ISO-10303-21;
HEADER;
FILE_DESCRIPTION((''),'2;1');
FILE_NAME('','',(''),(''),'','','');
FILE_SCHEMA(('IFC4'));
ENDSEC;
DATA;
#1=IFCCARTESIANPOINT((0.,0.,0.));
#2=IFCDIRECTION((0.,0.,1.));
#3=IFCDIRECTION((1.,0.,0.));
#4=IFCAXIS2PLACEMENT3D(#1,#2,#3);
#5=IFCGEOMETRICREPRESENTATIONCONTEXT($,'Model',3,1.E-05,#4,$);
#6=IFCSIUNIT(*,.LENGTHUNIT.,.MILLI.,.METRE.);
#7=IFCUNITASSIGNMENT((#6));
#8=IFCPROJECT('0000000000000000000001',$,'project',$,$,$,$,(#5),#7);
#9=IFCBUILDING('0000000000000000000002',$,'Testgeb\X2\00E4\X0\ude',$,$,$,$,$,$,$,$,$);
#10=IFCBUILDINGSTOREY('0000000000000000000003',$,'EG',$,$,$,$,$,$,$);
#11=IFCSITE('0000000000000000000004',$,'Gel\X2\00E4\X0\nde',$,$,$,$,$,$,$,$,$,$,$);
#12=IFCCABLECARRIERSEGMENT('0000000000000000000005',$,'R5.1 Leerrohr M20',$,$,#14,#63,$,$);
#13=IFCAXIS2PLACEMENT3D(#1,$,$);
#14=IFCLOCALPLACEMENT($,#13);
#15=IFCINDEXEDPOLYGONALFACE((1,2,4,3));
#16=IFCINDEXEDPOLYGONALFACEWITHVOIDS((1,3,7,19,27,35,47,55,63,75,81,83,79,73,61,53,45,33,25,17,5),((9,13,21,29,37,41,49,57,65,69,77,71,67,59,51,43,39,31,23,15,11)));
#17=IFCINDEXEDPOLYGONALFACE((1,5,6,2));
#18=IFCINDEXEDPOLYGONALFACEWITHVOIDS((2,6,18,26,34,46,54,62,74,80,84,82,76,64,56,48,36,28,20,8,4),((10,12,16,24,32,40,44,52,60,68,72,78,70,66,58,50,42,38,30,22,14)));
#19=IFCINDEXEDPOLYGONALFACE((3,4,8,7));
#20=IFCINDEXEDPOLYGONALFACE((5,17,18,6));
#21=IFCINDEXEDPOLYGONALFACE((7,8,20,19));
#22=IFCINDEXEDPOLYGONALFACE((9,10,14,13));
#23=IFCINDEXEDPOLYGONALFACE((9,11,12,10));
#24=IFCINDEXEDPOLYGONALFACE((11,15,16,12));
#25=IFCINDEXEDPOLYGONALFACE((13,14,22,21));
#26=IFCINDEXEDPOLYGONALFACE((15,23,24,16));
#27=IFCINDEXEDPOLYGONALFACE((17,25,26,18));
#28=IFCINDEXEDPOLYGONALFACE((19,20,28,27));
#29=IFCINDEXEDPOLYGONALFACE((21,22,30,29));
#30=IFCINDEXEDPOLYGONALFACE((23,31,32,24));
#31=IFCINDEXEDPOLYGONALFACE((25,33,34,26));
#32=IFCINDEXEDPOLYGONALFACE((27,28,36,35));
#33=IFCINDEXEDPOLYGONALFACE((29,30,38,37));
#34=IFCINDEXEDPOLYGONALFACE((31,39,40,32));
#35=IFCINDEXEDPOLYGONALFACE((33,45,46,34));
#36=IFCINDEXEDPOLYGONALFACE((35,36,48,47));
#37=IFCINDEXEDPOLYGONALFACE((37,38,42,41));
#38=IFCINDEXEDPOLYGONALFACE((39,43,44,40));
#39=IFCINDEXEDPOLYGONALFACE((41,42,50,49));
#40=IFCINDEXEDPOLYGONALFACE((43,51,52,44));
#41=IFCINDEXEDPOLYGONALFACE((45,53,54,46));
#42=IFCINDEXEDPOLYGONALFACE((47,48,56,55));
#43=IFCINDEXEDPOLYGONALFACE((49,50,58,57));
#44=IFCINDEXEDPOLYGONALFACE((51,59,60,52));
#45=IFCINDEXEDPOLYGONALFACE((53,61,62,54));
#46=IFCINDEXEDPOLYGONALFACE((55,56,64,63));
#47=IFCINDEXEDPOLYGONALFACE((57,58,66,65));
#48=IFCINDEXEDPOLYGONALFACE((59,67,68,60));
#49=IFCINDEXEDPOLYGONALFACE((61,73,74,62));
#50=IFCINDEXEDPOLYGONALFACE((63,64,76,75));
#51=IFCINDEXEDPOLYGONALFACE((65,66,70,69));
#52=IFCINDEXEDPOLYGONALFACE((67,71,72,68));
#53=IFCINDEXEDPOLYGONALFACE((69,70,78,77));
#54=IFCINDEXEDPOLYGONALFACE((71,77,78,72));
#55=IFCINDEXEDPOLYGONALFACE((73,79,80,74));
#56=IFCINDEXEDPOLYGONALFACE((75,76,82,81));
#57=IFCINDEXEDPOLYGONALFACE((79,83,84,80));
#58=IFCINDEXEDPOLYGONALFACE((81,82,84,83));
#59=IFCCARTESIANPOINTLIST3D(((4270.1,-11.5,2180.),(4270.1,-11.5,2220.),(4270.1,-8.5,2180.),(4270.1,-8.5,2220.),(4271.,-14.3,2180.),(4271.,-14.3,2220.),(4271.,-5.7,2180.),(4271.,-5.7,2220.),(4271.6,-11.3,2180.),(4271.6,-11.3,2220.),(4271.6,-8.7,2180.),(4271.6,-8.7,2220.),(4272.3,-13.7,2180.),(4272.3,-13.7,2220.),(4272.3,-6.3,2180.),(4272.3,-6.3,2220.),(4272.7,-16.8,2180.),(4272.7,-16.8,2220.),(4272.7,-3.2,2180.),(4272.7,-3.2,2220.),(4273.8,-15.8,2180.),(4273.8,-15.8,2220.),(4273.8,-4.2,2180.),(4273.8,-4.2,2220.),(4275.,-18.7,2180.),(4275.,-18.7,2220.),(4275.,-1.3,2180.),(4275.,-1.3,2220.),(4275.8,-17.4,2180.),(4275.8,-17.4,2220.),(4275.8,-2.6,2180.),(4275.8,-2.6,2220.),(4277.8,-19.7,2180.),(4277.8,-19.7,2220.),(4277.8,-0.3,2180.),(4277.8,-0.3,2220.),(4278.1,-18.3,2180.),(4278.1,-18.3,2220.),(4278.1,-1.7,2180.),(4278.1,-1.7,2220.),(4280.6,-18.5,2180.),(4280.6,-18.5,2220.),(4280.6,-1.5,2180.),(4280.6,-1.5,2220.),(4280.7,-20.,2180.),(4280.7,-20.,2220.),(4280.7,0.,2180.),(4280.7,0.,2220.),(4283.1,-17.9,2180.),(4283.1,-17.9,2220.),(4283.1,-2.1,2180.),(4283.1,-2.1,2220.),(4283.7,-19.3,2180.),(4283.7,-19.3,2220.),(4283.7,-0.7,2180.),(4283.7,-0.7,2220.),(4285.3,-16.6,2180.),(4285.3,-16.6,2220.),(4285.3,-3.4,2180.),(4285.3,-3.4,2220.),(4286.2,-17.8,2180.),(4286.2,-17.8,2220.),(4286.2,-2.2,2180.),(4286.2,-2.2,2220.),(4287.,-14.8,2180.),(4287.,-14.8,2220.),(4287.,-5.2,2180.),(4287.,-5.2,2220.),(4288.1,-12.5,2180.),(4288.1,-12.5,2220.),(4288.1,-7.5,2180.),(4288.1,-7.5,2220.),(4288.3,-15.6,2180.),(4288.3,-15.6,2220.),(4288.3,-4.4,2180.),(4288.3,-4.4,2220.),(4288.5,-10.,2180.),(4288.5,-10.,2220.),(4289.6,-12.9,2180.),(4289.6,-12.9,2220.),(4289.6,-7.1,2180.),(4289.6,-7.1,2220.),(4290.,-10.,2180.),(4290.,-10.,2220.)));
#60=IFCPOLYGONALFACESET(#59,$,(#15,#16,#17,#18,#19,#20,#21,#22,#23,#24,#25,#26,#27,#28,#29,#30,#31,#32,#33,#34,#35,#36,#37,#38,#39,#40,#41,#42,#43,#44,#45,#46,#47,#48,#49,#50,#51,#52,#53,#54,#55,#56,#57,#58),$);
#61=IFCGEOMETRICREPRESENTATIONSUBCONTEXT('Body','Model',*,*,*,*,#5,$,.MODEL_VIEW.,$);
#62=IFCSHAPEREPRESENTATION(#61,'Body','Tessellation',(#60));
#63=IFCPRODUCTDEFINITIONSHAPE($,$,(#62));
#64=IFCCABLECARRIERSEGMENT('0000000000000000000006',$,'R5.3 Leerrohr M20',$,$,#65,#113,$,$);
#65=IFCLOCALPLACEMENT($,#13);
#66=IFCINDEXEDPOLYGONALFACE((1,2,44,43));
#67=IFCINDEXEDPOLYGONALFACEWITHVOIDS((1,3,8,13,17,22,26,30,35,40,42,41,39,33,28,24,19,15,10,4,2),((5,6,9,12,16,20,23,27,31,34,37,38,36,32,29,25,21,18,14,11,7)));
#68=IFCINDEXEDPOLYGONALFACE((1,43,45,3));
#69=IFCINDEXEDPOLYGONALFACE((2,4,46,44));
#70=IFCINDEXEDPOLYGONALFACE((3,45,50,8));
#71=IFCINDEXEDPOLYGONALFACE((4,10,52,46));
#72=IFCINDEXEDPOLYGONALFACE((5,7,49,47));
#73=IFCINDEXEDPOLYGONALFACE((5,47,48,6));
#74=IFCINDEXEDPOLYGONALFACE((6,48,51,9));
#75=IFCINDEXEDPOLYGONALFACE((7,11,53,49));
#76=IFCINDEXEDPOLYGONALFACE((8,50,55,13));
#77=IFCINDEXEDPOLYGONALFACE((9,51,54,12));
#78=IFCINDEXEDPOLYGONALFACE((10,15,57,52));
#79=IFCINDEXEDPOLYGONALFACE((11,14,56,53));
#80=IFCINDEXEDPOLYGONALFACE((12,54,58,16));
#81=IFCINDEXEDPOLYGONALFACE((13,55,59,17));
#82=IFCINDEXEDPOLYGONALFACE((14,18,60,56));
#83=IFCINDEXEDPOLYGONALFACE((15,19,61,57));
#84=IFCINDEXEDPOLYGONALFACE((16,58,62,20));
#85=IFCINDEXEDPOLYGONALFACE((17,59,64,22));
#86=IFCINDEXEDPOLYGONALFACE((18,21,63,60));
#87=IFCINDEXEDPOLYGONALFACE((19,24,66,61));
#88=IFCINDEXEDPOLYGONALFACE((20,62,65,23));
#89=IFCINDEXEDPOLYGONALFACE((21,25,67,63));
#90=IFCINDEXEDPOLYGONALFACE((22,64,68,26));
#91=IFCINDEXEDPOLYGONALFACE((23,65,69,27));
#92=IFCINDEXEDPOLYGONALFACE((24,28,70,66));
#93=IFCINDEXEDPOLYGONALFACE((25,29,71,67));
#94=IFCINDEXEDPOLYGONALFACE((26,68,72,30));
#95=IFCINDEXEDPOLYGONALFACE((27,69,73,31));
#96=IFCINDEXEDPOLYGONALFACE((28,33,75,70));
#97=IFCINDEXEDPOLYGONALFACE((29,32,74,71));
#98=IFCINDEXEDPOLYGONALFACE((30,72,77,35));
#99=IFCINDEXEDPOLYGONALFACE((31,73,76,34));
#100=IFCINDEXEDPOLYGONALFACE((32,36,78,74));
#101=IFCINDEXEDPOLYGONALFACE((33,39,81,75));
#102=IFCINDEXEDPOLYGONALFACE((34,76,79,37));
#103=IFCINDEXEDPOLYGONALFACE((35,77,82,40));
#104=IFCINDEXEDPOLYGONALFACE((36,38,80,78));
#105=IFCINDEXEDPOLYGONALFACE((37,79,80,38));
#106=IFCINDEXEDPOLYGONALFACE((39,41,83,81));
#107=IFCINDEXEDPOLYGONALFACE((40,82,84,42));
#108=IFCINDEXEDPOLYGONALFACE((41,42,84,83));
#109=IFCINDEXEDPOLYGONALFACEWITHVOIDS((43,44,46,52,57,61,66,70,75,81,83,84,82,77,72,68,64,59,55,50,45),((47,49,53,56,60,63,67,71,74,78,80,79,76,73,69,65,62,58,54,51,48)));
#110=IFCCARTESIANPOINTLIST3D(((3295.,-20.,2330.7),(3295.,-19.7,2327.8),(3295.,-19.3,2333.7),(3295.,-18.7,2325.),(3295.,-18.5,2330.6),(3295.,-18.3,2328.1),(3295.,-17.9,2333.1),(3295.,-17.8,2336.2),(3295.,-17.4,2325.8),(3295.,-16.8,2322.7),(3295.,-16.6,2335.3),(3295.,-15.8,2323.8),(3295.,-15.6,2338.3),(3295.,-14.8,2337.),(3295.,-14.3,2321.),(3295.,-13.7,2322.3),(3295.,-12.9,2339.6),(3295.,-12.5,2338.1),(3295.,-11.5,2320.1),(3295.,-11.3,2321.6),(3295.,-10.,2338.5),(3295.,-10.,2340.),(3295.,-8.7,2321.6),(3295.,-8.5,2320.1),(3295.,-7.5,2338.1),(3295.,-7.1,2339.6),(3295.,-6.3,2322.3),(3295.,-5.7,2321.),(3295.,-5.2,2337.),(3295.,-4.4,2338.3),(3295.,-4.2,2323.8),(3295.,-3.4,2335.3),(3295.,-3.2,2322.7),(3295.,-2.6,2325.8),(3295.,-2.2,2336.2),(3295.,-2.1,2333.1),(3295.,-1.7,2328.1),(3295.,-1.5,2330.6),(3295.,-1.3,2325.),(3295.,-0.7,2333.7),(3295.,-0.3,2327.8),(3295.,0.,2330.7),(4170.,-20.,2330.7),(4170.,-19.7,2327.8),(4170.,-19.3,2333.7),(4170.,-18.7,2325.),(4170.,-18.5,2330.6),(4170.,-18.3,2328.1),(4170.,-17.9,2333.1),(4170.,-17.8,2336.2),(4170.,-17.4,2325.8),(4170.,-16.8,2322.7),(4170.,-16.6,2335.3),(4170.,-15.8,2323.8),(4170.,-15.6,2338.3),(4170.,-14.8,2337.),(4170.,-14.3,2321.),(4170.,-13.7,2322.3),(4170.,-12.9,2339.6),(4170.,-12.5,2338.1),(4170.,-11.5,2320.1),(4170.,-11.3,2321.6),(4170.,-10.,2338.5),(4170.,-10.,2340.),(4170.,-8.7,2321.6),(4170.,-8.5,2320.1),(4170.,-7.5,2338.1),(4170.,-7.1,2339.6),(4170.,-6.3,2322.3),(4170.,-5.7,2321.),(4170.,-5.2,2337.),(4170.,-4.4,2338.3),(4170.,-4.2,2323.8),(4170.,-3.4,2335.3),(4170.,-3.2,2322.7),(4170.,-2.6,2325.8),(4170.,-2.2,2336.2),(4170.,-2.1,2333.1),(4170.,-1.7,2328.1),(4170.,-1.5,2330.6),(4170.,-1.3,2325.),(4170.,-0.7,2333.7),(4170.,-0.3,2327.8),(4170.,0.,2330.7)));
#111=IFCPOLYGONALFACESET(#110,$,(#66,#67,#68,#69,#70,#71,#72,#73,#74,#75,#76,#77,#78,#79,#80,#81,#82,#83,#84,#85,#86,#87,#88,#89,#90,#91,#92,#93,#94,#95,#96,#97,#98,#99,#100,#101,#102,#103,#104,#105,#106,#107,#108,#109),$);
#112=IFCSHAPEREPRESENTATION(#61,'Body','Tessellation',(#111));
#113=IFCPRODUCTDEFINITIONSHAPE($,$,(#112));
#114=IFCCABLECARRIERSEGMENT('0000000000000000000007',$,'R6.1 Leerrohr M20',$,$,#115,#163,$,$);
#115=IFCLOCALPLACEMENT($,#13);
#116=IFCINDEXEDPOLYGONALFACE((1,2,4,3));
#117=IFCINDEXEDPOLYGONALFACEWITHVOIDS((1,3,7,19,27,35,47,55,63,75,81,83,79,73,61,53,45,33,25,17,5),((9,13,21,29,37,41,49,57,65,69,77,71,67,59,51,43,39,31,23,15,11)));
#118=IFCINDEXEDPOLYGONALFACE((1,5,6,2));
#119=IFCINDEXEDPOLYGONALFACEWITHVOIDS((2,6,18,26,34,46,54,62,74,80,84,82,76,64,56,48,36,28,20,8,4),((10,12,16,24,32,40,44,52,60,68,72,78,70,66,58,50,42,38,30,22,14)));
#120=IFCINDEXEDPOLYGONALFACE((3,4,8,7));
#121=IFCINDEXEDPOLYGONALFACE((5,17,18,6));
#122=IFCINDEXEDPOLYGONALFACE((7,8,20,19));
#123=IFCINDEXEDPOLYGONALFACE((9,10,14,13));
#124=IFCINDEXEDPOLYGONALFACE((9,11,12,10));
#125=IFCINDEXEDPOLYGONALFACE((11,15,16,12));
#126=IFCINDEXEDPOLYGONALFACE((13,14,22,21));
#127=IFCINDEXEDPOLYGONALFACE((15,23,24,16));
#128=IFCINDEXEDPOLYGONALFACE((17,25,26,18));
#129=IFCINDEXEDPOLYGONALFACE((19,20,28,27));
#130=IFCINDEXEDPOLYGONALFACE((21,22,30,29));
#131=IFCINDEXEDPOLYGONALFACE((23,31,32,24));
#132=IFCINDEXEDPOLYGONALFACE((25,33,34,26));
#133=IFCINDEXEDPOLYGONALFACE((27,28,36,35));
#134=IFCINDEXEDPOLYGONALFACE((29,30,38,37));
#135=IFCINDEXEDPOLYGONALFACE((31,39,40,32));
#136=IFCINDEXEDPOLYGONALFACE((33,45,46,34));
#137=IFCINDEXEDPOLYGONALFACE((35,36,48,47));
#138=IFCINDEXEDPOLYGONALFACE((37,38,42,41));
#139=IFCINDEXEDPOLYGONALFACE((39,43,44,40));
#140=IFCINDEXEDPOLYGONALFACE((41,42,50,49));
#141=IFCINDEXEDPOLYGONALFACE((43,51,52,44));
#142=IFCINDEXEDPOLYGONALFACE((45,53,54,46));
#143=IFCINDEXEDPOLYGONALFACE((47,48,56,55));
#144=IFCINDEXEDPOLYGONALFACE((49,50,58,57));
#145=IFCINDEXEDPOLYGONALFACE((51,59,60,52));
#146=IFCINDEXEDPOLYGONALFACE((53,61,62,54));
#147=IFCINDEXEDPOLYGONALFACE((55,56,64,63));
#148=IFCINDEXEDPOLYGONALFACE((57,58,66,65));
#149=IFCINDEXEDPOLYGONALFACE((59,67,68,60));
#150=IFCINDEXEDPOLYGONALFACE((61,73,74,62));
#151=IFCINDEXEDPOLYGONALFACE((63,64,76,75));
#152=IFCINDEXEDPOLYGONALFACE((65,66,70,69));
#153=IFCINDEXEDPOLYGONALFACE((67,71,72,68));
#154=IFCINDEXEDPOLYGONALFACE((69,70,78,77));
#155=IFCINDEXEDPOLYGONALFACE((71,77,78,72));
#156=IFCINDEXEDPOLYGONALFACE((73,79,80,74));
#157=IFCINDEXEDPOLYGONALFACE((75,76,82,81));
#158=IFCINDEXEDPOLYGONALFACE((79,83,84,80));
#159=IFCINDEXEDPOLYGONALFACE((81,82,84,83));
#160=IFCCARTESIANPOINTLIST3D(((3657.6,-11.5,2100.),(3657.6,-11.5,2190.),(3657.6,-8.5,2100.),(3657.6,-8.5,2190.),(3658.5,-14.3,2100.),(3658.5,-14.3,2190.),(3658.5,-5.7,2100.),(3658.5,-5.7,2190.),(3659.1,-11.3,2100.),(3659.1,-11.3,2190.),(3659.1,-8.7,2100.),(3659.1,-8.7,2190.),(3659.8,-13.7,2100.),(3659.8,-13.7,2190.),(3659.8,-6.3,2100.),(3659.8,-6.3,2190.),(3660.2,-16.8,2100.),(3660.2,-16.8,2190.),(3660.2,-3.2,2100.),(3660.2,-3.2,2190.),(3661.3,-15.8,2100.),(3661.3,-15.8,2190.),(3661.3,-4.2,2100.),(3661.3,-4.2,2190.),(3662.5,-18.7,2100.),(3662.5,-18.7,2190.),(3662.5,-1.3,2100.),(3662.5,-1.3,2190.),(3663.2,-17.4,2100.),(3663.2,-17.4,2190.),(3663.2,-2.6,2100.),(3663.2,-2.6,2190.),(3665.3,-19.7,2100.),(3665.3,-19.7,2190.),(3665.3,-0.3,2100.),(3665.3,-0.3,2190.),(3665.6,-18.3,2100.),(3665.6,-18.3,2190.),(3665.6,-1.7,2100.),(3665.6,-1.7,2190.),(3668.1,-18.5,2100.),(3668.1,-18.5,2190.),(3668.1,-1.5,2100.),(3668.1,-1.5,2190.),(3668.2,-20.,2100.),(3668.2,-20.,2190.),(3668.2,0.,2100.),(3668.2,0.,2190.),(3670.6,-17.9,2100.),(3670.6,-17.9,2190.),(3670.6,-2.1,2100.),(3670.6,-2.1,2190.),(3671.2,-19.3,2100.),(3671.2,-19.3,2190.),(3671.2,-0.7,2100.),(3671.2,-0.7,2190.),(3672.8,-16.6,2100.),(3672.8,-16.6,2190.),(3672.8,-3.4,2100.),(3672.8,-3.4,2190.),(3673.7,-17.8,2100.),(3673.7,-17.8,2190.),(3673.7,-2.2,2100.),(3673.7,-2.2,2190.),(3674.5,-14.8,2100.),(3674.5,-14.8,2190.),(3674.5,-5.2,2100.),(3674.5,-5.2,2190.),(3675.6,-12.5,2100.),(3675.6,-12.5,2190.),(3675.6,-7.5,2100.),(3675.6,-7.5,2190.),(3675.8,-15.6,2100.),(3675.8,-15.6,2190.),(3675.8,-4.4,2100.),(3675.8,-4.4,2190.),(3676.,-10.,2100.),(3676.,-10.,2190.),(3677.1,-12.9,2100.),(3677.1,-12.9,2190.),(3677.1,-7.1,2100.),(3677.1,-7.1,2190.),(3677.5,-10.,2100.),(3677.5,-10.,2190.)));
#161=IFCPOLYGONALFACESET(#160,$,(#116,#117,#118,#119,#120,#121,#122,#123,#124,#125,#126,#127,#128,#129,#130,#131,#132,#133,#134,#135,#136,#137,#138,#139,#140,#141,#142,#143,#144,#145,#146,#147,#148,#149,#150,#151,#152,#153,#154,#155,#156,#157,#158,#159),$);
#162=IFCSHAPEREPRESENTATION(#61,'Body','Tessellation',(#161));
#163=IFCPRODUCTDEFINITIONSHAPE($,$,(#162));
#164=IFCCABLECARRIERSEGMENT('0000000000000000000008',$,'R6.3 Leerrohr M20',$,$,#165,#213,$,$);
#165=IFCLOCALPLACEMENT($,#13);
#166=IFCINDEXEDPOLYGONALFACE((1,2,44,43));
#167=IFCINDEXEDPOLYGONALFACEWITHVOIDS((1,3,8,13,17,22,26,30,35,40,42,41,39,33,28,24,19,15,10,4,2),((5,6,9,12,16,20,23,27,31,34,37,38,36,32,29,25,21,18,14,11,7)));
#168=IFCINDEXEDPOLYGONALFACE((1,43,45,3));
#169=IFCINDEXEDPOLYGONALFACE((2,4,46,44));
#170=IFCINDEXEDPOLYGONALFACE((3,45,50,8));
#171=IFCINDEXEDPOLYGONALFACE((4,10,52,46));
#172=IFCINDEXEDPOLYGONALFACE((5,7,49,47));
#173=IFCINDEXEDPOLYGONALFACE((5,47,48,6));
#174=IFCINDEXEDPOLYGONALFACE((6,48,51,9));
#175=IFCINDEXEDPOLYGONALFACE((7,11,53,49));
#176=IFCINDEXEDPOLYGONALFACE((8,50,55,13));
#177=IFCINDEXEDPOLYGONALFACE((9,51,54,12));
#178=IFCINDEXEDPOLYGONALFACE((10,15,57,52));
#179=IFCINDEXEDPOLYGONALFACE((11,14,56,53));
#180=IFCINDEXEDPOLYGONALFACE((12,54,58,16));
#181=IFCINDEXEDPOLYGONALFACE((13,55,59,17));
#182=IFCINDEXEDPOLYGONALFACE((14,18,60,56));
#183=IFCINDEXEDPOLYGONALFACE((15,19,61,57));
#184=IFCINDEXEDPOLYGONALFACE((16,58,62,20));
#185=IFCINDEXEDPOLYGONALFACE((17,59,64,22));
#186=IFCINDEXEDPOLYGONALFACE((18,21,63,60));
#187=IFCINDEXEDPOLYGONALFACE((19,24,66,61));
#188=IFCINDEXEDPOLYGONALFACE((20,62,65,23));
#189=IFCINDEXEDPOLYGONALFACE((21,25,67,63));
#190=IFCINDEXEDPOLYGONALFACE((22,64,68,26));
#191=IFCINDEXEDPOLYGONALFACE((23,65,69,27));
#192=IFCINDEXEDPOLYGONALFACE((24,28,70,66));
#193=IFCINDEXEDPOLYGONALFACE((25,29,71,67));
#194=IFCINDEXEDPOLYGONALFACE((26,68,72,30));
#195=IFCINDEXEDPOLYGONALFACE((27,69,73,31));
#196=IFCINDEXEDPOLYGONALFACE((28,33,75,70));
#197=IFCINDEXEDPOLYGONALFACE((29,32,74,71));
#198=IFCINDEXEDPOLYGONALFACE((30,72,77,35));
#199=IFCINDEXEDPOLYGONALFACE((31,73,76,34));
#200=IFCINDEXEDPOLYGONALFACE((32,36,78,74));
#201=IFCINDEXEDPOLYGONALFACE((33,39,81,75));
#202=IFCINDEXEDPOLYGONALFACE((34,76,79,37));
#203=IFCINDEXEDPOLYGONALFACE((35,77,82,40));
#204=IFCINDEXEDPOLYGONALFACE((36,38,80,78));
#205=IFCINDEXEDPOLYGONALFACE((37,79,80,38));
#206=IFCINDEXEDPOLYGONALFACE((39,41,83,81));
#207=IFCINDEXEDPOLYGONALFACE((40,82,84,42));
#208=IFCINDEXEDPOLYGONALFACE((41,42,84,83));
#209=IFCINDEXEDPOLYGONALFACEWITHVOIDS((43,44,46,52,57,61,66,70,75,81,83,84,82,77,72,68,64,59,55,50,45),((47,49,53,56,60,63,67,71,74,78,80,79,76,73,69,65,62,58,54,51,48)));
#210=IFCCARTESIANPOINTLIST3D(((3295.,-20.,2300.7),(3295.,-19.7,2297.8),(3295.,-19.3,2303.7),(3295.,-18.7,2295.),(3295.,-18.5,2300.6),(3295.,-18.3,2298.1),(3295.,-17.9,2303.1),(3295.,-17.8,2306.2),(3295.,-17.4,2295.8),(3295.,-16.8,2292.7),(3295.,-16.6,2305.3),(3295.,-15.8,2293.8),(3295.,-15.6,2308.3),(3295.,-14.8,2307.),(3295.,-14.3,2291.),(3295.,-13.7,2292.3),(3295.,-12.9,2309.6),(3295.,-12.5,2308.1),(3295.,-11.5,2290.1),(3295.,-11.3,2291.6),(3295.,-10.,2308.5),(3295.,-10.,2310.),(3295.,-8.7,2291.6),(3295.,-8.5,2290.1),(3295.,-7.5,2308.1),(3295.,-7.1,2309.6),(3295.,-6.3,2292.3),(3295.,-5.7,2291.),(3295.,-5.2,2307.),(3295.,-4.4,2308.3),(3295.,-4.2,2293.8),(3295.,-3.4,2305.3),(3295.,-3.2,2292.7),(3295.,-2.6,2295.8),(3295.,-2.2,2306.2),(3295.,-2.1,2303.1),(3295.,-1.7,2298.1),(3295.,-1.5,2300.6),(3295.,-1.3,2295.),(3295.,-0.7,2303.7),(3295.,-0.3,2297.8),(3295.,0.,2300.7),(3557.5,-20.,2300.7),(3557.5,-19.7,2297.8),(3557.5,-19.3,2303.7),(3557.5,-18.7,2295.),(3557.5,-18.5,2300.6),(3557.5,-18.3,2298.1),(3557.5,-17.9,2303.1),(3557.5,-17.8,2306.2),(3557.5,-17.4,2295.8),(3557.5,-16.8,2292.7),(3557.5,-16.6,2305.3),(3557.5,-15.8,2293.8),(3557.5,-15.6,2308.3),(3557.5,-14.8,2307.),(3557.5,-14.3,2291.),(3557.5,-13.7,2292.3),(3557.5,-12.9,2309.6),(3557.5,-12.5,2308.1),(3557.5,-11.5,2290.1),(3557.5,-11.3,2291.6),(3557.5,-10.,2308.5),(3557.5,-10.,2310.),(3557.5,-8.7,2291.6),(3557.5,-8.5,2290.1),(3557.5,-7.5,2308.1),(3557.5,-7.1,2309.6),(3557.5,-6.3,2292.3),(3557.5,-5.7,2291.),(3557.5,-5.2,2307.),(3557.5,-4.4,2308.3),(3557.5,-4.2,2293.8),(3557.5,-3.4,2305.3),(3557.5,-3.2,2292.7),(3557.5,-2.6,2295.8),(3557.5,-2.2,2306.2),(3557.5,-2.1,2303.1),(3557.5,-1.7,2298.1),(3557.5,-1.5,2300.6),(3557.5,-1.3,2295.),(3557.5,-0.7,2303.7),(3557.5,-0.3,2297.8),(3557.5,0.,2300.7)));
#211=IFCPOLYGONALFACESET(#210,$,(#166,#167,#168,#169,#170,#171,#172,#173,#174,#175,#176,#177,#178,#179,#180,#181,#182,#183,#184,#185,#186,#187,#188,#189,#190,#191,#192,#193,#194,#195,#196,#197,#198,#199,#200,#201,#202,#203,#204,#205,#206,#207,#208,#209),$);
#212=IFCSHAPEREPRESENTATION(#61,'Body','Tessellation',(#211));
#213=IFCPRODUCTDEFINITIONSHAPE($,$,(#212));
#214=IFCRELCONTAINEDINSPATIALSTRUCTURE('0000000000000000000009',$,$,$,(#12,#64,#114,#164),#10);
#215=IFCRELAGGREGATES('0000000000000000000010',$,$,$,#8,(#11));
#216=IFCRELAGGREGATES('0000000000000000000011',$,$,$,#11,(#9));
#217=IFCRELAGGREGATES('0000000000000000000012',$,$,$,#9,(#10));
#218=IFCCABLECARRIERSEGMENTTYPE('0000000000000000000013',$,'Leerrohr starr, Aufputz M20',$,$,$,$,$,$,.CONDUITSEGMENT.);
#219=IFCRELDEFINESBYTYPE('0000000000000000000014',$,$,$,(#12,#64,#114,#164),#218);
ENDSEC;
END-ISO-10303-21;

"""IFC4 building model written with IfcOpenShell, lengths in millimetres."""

from ifc_helpers import new_model, si_unit, frame, origin_with_axes, place, context, subcontext, project, spatial, hollow_circle, extrude, type_object, element, save


model = new_model("IFC4")

# Units and contexts
model_context = context("Model", 3, precision=1e-05, world=origin_with_axes())
body_context = subcontext(model_context, "Body", "Model", "MODEL_VIEW")
ifc_project = project(units=[si_unit("LENGTHUNIT", "METRE", prefix="MILLI")], contexts=[model_context])

# Site, building, storey
site = spatial("IfcSite", under=ifc_project, Name="Gelände")
building = spatial("IfcBuilding", under=site, Name="Testgebäude")
storey = spatial("IfcBuildingStorey", under=building, Name="EG")

# Cable carrier segments
cable_carrier_segment_type_1 = type_object("IfcCableCarrierSegmentType", Name="Leerrohr starr, Aufputz M20", PredefinedType="CONDUITSEGMENT")
cable_carrier_segment_1_placement = place(None, frame((4280.0, -10.0, 2180.0), z_axis=(0.0, 0.0, 1.0), x_axis=(1.0, 0.0, 0.0)))
element("IfcCableCarrierSegment", 1, at=cable_carrier_segment_1_placement, inside=storey, type_object=cable_carrier_segment_type_1, Name="R5.1 Leerrohr M20", context=body_context, shape_type="SweptSolid", body=[
    extrude(hollow_circle(Radius=10.0, WallThickness=1.5), None, (0.0, 0.0, 1.0), 40.0),
])
cable_carrier_segment_2_placement = place(None, frame((4170.0, -10.0, 2330.0), z_axis=(-1.0, 0.0, 0.0), x_axis=(0.0, 0.0, 1.0)))
element("IfcCableCarrierSegment", 2, at=cable_carrier_segment_2_placement, inside=storey, type_object=cable_carrier_segment_type_1, Name="R5.3 Leerrohr M20", context=body_context, shape_type="SweptSolid", body=[
    extrude(hollow_circle(Radius=10.0, WallThickness=1.5), None, (0.0, 0.0, 1.0), 875.0),
])
cable_carrier_segment_3_placement = place(None, frame((3667.5, -10.0, 2100.0), z_axis=(0.0, 0.0, 1.0), x_axis=(1.0, 0.0, 0.0)))
element("IfcCableCarrierSegment", 3, at=cable_carrier_segment_3_placement, inside=storey, type_object=cable_carrier_segment_type_1, Name="R6.1 Leerrohr M20", context=body_context, shape_type="SweptSolid", body=[
    extrude(hollow_circle(Radius=10.0, WallThickness=1.5), None, (0.0, 0.0, 1.0), 90.0),
])
cable_carrier_segment_4_placement = place(None, frame((3557.5, -10.0, 2300.0), z_axis=(-1.0, 0.0, 0.0), x_axis=(0.0, 0.0, 1.0)))
element("IfcCableCarrierSegment", 4, at=cable_carrier_segment_4_placement, inside=storey, type_object=cable_carrier_segment_type_1, Name="R6.3 Leerrohr M20", context=body_context, shape_type="SweptSolid", body=[
    extrude(hollow_circle(Radius=10.0, WallThickness=1.5), None, (0.0, 0.0, 1.0), 262.5),
])

save(model, "model.ifc")
